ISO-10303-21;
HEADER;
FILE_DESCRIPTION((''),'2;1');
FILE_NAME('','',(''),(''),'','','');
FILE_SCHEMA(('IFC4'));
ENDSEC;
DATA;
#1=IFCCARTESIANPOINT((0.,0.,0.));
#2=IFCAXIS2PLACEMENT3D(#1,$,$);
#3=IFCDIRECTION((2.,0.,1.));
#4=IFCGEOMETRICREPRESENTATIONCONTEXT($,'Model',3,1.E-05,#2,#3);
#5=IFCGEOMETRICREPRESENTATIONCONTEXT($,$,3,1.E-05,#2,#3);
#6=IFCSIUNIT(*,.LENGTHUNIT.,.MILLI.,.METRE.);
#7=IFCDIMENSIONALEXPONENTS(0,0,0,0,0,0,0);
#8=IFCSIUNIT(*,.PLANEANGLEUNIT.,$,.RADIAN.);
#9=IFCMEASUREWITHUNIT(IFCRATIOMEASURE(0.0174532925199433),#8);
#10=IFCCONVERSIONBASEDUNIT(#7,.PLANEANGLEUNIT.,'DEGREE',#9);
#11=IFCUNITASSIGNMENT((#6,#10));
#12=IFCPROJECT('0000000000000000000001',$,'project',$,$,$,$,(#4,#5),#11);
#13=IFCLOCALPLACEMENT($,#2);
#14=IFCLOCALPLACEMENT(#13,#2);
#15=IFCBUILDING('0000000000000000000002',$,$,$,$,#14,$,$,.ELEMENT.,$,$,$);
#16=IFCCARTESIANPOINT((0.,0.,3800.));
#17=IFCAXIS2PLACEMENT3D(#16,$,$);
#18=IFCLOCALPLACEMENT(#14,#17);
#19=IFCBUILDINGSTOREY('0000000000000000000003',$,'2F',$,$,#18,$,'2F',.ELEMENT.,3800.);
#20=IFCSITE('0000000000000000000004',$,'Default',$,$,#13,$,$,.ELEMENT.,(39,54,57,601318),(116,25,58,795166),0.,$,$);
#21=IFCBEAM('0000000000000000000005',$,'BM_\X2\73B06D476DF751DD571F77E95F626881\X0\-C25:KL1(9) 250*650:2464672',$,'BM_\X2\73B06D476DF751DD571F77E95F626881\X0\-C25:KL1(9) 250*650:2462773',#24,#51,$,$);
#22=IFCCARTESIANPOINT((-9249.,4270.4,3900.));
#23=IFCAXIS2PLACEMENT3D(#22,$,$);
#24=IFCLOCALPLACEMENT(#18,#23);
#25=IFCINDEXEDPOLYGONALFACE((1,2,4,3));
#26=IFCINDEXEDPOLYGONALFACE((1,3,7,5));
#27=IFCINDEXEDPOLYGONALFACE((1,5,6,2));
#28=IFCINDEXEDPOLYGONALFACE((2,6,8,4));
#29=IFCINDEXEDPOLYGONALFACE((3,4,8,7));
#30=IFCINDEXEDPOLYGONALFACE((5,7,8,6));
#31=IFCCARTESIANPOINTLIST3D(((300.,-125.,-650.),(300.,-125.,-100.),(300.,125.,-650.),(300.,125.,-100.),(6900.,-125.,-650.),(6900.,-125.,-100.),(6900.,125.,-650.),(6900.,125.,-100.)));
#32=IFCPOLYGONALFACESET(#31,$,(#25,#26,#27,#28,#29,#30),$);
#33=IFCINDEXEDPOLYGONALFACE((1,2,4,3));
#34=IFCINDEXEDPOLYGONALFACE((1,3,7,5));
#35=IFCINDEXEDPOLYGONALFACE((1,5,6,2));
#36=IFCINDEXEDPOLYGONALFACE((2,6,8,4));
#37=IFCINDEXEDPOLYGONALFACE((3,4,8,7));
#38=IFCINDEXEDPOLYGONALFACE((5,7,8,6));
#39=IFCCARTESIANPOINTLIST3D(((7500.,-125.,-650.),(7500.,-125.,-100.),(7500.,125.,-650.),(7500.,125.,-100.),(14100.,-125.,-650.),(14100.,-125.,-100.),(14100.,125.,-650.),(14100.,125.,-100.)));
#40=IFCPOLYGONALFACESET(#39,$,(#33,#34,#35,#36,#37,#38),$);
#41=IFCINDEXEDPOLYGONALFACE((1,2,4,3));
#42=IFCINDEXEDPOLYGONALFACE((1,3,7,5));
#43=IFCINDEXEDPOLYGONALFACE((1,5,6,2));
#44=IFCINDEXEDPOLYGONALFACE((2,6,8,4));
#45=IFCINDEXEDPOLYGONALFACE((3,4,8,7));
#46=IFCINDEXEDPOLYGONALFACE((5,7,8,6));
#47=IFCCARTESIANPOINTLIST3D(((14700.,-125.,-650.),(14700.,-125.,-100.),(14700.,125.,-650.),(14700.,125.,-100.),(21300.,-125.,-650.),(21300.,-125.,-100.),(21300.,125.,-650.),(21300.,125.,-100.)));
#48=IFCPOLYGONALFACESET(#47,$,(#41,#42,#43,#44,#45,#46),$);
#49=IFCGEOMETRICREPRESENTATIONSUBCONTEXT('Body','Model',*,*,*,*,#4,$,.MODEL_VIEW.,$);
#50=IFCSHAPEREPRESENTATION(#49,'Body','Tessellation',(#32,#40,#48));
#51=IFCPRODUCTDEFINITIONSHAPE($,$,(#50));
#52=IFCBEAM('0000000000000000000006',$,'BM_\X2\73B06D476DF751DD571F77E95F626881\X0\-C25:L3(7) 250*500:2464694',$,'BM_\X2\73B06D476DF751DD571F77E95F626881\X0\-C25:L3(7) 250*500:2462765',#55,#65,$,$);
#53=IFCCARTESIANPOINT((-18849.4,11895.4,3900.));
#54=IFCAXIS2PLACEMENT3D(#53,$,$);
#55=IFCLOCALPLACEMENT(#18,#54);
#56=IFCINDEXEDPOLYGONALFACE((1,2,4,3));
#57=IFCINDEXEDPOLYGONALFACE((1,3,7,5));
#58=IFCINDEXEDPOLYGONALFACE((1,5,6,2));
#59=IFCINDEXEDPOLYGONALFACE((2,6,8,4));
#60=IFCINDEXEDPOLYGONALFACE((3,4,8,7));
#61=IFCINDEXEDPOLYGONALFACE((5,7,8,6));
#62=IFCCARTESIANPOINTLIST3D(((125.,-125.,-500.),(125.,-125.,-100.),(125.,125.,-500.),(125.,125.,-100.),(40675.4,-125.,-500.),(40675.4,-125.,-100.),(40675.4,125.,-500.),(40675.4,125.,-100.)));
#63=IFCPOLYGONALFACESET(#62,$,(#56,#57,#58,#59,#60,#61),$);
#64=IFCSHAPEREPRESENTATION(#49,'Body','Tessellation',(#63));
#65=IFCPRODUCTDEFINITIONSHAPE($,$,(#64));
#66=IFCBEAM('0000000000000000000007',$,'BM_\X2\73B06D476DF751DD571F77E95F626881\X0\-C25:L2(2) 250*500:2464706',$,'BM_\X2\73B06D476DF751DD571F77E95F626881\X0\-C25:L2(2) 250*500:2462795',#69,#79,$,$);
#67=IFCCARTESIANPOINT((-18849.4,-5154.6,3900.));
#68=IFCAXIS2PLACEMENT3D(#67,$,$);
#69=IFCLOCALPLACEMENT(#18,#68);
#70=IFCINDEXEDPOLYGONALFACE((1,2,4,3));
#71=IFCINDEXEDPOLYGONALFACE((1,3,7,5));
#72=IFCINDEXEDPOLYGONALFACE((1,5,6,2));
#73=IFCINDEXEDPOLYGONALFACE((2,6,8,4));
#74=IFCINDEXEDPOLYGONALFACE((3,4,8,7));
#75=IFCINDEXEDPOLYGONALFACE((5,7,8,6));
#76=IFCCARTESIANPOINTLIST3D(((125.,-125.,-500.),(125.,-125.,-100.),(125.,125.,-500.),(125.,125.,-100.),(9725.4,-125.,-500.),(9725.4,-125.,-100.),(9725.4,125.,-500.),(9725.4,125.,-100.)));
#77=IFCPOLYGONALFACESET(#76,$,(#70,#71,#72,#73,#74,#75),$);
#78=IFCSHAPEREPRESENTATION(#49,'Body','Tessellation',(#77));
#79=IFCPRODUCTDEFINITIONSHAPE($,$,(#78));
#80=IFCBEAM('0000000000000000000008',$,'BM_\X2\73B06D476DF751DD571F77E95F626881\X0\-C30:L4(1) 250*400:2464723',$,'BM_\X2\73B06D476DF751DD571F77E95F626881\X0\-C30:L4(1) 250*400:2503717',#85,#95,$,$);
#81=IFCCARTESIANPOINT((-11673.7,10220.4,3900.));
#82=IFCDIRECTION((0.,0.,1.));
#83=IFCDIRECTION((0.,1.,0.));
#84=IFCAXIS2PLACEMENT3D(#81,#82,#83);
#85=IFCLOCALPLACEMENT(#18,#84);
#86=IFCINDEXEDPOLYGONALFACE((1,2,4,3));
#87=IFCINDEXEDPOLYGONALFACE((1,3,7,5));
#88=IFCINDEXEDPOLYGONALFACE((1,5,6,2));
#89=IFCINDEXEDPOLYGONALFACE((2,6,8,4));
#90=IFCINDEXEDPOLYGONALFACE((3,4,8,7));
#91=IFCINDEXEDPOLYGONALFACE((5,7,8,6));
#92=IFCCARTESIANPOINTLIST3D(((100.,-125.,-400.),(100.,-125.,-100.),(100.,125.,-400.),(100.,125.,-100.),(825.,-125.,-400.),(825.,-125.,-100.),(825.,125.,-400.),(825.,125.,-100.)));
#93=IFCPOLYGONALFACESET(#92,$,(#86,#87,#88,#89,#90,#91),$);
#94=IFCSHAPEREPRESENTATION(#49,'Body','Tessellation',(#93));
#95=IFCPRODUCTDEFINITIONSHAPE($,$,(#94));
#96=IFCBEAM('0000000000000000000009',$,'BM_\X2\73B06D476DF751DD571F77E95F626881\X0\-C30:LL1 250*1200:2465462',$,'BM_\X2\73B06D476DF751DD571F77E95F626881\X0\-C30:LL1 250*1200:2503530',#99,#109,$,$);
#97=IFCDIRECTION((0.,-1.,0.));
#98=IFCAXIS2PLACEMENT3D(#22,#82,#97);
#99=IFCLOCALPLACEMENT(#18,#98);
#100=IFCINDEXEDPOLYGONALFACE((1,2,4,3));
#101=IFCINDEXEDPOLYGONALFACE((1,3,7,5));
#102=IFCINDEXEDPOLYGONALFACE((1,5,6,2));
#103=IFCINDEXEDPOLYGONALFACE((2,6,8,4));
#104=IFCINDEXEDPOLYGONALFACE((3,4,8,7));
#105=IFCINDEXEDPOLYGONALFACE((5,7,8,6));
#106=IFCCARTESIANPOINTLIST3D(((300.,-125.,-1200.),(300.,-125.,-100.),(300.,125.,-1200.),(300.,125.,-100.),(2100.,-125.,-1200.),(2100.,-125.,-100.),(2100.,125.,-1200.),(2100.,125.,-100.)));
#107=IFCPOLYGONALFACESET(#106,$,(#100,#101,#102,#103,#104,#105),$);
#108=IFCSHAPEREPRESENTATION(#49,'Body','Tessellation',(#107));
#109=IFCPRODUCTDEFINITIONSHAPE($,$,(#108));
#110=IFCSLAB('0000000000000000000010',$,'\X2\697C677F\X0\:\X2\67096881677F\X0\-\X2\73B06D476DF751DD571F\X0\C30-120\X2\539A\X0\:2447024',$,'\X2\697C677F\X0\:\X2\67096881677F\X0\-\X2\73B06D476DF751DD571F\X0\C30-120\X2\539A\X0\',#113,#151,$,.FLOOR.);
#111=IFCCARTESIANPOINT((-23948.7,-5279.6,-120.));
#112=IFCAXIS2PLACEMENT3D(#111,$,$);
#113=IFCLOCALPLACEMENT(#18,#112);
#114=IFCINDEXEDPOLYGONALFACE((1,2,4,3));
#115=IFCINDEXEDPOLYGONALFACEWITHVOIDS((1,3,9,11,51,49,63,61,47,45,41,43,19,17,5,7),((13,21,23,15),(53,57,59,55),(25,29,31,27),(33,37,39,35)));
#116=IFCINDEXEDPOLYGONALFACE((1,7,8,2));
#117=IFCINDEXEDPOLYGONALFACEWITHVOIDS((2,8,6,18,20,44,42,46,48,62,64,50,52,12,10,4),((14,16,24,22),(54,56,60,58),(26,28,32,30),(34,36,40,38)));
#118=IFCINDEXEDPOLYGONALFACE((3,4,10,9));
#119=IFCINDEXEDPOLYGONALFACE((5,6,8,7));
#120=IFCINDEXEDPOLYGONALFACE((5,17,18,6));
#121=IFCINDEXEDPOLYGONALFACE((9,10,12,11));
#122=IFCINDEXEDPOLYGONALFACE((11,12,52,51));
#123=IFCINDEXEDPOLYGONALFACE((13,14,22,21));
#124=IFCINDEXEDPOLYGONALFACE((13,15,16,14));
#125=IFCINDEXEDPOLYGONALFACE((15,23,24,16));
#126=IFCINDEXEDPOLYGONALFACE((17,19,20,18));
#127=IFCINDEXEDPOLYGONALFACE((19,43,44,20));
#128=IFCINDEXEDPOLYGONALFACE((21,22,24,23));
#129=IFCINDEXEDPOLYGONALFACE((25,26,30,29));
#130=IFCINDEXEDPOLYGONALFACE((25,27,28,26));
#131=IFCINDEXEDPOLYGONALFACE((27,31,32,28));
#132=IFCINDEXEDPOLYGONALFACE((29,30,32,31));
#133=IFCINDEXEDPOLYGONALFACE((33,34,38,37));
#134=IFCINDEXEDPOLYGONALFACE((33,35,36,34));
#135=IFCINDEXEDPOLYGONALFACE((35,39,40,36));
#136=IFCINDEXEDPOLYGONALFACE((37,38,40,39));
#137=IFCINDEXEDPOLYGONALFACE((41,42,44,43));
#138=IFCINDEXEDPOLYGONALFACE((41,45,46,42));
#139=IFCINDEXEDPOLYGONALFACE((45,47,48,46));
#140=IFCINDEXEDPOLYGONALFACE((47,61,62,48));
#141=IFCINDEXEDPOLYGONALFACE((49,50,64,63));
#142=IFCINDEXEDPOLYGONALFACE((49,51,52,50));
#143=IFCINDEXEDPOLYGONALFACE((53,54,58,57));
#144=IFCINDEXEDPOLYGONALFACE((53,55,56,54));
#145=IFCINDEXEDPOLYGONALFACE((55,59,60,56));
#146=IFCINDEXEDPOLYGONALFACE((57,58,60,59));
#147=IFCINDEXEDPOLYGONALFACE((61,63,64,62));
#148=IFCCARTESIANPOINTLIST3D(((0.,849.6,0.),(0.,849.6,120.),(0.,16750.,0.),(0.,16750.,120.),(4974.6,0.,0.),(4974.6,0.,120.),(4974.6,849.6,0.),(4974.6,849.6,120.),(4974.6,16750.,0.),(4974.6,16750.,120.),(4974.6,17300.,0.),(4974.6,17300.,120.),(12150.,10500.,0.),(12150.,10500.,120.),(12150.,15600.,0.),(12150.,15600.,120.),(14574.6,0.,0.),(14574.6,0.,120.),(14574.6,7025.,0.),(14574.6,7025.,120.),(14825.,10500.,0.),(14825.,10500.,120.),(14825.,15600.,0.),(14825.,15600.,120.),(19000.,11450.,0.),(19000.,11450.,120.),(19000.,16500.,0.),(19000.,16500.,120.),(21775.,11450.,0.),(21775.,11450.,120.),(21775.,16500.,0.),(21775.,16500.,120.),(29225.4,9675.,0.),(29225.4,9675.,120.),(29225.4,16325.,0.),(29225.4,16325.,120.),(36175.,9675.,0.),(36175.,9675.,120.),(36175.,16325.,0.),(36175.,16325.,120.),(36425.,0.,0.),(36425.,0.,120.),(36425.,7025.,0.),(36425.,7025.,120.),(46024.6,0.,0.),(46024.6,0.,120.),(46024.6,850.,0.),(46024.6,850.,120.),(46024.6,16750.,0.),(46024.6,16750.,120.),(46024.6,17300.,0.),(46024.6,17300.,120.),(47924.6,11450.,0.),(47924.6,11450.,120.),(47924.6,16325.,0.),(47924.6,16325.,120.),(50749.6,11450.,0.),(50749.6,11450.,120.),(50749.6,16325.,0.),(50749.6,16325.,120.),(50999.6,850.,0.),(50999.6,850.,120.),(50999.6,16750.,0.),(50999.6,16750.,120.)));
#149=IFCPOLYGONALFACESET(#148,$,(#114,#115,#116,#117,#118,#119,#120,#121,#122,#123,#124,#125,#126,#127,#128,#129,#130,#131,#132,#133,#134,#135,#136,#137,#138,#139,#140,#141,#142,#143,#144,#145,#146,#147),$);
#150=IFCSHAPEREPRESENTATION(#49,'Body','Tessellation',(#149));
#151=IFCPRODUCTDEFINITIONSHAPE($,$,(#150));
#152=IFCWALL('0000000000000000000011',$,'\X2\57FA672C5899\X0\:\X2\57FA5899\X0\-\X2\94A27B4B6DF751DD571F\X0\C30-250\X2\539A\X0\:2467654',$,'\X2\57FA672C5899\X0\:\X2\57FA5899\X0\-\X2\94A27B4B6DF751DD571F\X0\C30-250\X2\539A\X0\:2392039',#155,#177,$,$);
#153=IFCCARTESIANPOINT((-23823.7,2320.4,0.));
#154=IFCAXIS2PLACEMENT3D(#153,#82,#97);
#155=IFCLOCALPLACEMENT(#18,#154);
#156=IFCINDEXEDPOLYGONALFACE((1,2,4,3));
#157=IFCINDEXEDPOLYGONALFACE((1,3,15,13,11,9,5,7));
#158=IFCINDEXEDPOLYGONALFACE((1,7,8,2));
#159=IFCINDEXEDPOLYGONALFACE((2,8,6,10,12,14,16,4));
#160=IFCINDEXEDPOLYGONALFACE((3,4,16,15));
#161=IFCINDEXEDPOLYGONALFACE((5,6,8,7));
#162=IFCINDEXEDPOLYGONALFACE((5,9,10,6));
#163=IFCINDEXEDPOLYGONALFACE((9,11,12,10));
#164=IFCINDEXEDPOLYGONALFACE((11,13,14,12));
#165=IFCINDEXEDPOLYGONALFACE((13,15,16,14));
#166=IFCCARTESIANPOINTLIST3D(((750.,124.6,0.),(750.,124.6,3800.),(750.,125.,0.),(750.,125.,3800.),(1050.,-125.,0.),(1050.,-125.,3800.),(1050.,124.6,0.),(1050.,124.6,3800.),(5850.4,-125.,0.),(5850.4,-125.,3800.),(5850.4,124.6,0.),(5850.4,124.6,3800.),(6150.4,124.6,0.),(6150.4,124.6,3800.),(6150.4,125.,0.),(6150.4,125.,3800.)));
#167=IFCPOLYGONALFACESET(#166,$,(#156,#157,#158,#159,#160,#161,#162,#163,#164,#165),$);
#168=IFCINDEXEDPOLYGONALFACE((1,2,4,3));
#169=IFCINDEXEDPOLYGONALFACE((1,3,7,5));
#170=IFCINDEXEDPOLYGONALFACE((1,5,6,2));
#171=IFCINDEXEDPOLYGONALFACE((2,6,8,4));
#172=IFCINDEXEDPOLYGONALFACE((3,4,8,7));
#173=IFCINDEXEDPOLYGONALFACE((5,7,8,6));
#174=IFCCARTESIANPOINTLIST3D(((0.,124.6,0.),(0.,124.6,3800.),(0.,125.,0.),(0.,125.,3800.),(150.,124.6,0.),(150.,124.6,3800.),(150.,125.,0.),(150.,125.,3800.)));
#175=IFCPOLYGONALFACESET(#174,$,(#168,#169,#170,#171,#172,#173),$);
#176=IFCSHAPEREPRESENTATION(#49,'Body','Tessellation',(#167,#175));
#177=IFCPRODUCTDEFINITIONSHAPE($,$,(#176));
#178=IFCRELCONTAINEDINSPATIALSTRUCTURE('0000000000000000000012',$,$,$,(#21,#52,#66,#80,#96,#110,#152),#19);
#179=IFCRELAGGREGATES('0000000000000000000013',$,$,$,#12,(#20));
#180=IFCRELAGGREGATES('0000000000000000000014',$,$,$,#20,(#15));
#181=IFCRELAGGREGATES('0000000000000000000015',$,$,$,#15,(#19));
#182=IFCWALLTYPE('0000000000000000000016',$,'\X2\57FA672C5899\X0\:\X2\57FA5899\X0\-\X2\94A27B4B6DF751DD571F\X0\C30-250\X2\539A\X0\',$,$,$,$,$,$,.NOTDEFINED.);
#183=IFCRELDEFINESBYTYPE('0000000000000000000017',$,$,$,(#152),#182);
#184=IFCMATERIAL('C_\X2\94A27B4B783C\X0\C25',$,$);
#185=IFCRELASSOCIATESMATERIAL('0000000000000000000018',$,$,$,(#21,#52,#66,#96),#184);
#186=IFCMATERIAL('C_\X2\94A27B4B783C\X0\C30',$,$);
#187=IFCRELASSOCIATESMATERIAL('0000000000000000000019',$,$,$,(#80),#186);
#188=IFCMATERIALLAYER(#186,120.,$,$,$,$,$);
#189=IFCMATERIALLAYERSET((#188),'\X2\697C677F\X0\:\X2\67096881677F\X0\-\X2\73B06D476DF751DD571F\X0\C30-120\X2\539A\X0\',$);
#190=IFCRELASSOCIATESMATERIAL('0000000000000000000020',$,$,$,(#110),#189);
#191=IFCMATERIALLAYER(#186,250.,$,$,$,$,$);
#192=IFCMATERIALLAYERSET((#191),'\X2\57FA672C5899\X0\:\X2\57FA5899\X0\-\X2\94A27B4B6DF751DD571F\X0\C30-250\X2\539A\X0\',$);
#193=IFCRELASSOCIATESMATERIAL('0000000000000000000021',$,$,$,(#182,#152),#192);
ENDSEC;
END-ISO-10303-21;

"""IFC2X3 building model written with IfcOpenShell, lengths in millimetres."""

from ifc_helpers import new_model, entity, si_unit, converted_unit, direction, frame, frame_2d, origin, origin_2d_with_axis, place, context, subcontext, project, spatial, polyline, rectangle, outline, extrude, material, layer, layer_set, layer_usage, type_object, element, save


model = new_model("IFC2X3")

# Units and contexts
model_context = context("Model", 3, precision=1e-05, world=origin(), true_north=direction((2.0, 0.0, 1.0)))
context_of_model = context(None, 3, precision=1e-05, world=origin(), true_north=direction((2.0, 0.0, 1.0)))
body_context = subcontext(model_context, "Body", "Model", "MODEL_VIEW")
ifc_project = project(units=[si_unit("LENGTHUNIT", "METRE", prefix="MILLI"), converted_unit("PLANEANGLEUNIT", "DEGREE", entity("IfcRatioMeasure", 0.0174532925199433), si_unit("PLANEANGLEUNIT", "RADIAN"), dimensions=[0, 0, 0, 0, 0, 0, 0])], contexts=[model_context, context_of_model])

# Site, building, storey
site_placement = place(None, origin())
site = spatial("IfcSite", under=ifc_project, at=site_placement, Name="Default", CompositionType="ELEMENT", RefLatitude=(39, 54, 57, 601318), RefLongitude=(116, 25, 58, 795166), RefElevation=0.0)
building_placement = place(site_placement, origin())
building = spatial("IfcBuilding", under=site, at=building_placement, CompositionType="ELEMENT")
storey_placement = place(building_placement, frame((0.0, 0.0, 3800.0)))
storey = spatial("IfcBuildingStorey", under=building, at=storey_placement, Name="2F", LongName="2F", CompositionType="ELEMENT", Elevation=3800.0)

# Beams
ifc_material_1 = material(Name="C_钢筋砼C25")
beam_1_placement = place(storey_placement, frame((-9249.0, 4270.4, 3900.0)))
element("IfcBeam", 1, at=beam_1_placement, inside=storey, material=ifc_material_1, Name="BM_现浇混凝土矩形梁-C25:KL1(9) 250*650:2464672", ObjectType="BM_现浇混凝土矩形梁-C25:KL1(9) 250*650:2462773", context=body_context, shape_type="SweptSolid", body=[
    extrude(rectangle(XDim=550.0, YDim=250.0, at=frame_2d((0.0, 0.0), x_axis=(1.0, 0.0))), frame((300.0, 0.0, -375.0), z_axis=(1.0, 0.0, 0.0), x_axis=(0.0, 0.0, 1.0)), (0.0, 0.0, 1.0), 6600.0),
    extrude(rectangle(XDim=550.0, YDim=250.0, at=frame_2d((0.0, 0.0), x_axis=(1.0, 0.0))), frame((7500.0, 0.0, -375.0), z_axis=(1.0, 0.0, 0.0), x_axis=(0.0, 0.0, 1.0)), (0.0, 0.0, 1.0), 6600.0),
    extrude(rectangle(XDim=550.0, YDim=250.0, at=frame_2d((-45.0, 25.0), x_axis=(1.0, 0.0))), frame((14700.0, 25.0, -330.0), z_axis=(1.0, 0.0, 0.0), x_axis=(0.0, 0.0, 1.0)), (0.0, 0.0, 1.0), 6600.0),
])
beam_2_placement = place(storey_placement, frame((-18849.4, 11895.4, 3900.0)))
element("IfcBeam", 2, at=beam_2_placement, inside=storey, material=ifc_material_1, Name="BM_现浇混凝土矩形梁-C25:L3(7) 250*500:2464694", ObjectType="BM_现浇混凝土矩形梁-C25:L3(7) 250*500:2462765", context=body_context, shape_type="SweptSolid", body=[
    extrude(rectangle(XDim=400.0, YDim=250.0, at=frame_2d((0.0, 0.0), x_axis=(1.0, 0.0))), frame((125.0, 0.0, -300.0), z_axis=(1.0, 0.0, 0.0), x_axis=(0.0, 0.0, -1.0)), (0.0, 0.0, 1.0), 40550.4),
])
beam_3_placement = place(storey_placement, frame((-18849.4, -5154.6, 3900.0)))
element("IfcBeam", 3, at=beam_3_placement, inside=storey, material=ifc_material_1, Name="BM_现浇混凝土矩形梁-C25:L2(2) 250*500:2464706", ObjectType="BM_现浇混凝土矩形梁-C25:L2(2) 250*500:2462795", context=body_context, shape_type="SweptSolid", body=[
    extrude(rectangle(XDim=400.0, YDim=250.0, at=frame_2d((0.0, 0.0), x_axis=(1.0, 0.0))), frame((125.0, 0.0, -300.0), z_axis=(1.0, 0.0, 0.0), x_axis=(0.0, 0.0, -1.0)), (0.0, 0.0, 1.0), 9600.4),
])
ifc_material_2 = material(Name="C_钢筋砼C30")
beam_4_placement = place(storey_placement, frame((-11673.7, 10220.4, 3900.0), z_axis=(0.0, 0.0, 1.0), x_axis=(0.0, 1.0, 0.0)))
element("IfcBeam", 4, at=beam_4_placement, inside=storey, material=ifc_material_2, Name="BM_现浇混凝土矩形梁-C30:L4(1) 250*400:2464723", ObjectType="BM_现浇混凝土矩形梁-C30:L4(1) 250*400:2503717", context=body_context, shape_type="SweptSolid", body=[
    extrude(rectangle(XDim=300.0, YDim=250.0, at=frame_2d((0.0, 0.0), x_axis=(1.0, 0.0))), frame((100.0, 0.0, -250.0), z_axis=(1.0, 0.0, 0.0), x_axis=(0.0, 0.0, -1.0)), (0.0, 0.0, 1.0), 725.0),
])
beam_5_placement = place(storey_placement, frame((-9249.0, 4270.4, 3900.0), z_axis=(0.0, 0.0, 1.0), x_axis=(0.0, -1.0, 0.0)))
element("IfcBeam", 5, at=beam_5_placement, inside=storey, material=ifc_material_1, Name="BM_现浇混凝土矩形梁-C30:LL1 250*1200:2465462", ObjectType="BM_现浇混凝土矩形梁-C30:LL1 250*1200:2503530", context=body_context, shape_type="SweptSolid", body=[
    extrude(rectangle(XDim=1100.0, YDim=250.0, at=frame_2d((0.0, 0.0), x_axis=(1.0, 0.0))), frame((300.0, 0.0, -650.0), z_axis=(1.0, 0.0, 0.0), x_axis=(0.0, 0.0, -1.0)), (0.0, 0.0, 1.0), 1800.0),
])

# Slab, openings
ifc_layer_1 = layer(ifc_material_2, 120.0)
ifc_layer_set_1 = layer_set([ifc_layer_1], Name="楼板:有梁板-现浇混凝土C30-120厚")
ifc_layer_usage_1 = layer_usage(ifc_layer_set_1, "AXIS3", "POSITIVE", 0.0)
slab_placement = place(storey_placement, frame((-23948.7, -5279.6, -120.0)))
slab = element("IfcSlab", 6, at=slab_placement, inside=storey, material=ifc_layer_usage_1, Name="楼板:有梁板-现浇混凝土C30-120厚:2447024", ObjectType="楼板:有梁板-现浇混凝土C30-120厚", PredefinedType="FLOOR", context=body_context, shape_type="SweptSolid", body=[
    extrude(outline(polyline([(-20524.8, 8100.0), (-25499.8, 8100.0), (-25499.8, -7800.0), (-20524.8, -7800.0), (-20524.8, -8650.0), (-10925.2, -8650.0), (-10925.2, -1625.0), (10925.2, -1625.0), (10925.2, -8650.0), (20525.2, -8650.0), (20525.2, -7800.4), (25499.8, -7800.4), (25499.8, 8100.0), (20525.2, 8100.0), (20525.2, 8650.0), (-20524.8, 8650.0), (-20524.8, 8100.0)])), frame((25499.8, 8650.0, 120.0), z_axis=(0.0, 0.0, -1.0), x_axis=(-1.0, 0.0, 0.0)), (0.0, 0.0, 1.0), 120.0),
])
opening_1_placement = place(slab_placement, frame((13487.5, 13050.0, 120.0)))
element("IfcOpeningElement", 7, at=opening_1_placement, cuts=slab, ObjectType="Opening", context=body_context, shape_type="SweptSolid", body=[
    extrude(rectangle(XDim=2675.0, YDim=5100.0, at=origin_2d_with_axis()), frame((0.0, 0.0, 0.0), z_axis=(0.0, 0.0, -1.0), x_axis=(1.0, 0.0, 0.0)), (0.0, 0.0, 1.0), 120.0),
])
opening_2_placement = place(slab_placement, frame((20387.5, 13975.0, 120.0)))
element("IfcOpeningElement", 8, at=opening_2_placement, cuts=slab, ObjectType="Opening", context=body_context, shape_type="SweptSolid", body=[
    extrude(rectangle(XDim=2775.0, YDim=5050.0, at=origin_2d_with_axis()), frame((0.0, 0.0, 0.0), z_axis=(0.0, 0.0, -1.0), x_axis=(1.0, 0.0, 0.0)), (0.0, 0.0, 1.0), 120.0),
])
opening_3_placement = place(slab_placement, frame((32700.2, 13000.0, 120.0)))
element("IfcOpeningElement", 9, at=opening_3_placement, cuts=slab, ObjectType="Opening", context=body_context, shape_type="SweptSolid", body=[
    extrude(rectangle(XDim=6650.0, YDim=6949.6, at=origin_2d_with_axis()), frame((0.0, 0.0, 0.0), z_axis=(0.0, 0.0, 1.0), x_axis=(0.0, -1.0, 0.0)), (0.0, 0.0, -1.0), 120.0),
])
opening_4_placement = place(slab_placement, frame((49337.1, 13887.5, 120.0)))
element("IfcOpeningElement", 10, at=opening_4_placement, cuts=slab, ObjectType="Opening", context=body_context, shape_type="SweptSolid", body=[
    extrude(rectangle(XDim=4875.0, YDim=2825.0, at=origin_2d_with_axis()), frame((0.0, 0.0, 0.0), z_axis=(0.0, 0.0, -1.0), x_axis=(0.0, -1.0, 0.0)), (0.0, 0.0, 1.0), 120.0),
])

# Wall
ifc_layer_2 = layer(ifc_material_2, 250.0)
ifc_layer_set_2 = layer_set([ifc_layer_2], Name="基本墙:基墙-钢筋混凝土C30-250厚")
wall_type_1 = type_object("IfcWallType", Name="基本墙:基墙-钢筋混凝土C30-250厚", PredefinedType="NOTDEFINED", material=ifc_layer_set_2)
wall_1_placement = place(storey_placement, frame((-23823.7, 2320.4, 0.0), z_axis=(0.0, 0.0, 1.0), x_axis=(0.0, -1.0, 0.0)))
element("IfcWall", 11, at=wall_1_placement, inside=storey, type_object=wall_type_1, material=ifc_layer_set_2, Name="基本墙:基墙-钢筋混凝土C30-250厚:2467654", ObjectType="基本墙:基墙-钢筋混凝土C30-250厚:2392039", context=body_context, shape_type="SweptSolid", body=[
    extrude(outline(polyline([(-2700.2, -62.3), (-2700.2, -62.7), (2700.2, -62.7), (2700.2, -62.3), (2400.2, -62.3), (2400.2, 187.3), (-2400.2, 187.3), (-2400.2, -62.3), (-2700.2, -62.3)])), frame((3450.2, 62.3, 0.0), z_axis=(0.0, 0.0, -1.0), x_axis=(1.0, 0.0, 0.0)), (0.0, 0.0, -1.0), 3800.0),
    extrude(rectangle(XDim=150.0, YDim=0.4, at=frame_2d((0.0, 0.0), x_axis=(1.0, 0.0))), frame((75.0, 124.8, 0.0)), (0.0, 0.0, 1.0), 3800.0),
])

save(model, "model.ifc")
